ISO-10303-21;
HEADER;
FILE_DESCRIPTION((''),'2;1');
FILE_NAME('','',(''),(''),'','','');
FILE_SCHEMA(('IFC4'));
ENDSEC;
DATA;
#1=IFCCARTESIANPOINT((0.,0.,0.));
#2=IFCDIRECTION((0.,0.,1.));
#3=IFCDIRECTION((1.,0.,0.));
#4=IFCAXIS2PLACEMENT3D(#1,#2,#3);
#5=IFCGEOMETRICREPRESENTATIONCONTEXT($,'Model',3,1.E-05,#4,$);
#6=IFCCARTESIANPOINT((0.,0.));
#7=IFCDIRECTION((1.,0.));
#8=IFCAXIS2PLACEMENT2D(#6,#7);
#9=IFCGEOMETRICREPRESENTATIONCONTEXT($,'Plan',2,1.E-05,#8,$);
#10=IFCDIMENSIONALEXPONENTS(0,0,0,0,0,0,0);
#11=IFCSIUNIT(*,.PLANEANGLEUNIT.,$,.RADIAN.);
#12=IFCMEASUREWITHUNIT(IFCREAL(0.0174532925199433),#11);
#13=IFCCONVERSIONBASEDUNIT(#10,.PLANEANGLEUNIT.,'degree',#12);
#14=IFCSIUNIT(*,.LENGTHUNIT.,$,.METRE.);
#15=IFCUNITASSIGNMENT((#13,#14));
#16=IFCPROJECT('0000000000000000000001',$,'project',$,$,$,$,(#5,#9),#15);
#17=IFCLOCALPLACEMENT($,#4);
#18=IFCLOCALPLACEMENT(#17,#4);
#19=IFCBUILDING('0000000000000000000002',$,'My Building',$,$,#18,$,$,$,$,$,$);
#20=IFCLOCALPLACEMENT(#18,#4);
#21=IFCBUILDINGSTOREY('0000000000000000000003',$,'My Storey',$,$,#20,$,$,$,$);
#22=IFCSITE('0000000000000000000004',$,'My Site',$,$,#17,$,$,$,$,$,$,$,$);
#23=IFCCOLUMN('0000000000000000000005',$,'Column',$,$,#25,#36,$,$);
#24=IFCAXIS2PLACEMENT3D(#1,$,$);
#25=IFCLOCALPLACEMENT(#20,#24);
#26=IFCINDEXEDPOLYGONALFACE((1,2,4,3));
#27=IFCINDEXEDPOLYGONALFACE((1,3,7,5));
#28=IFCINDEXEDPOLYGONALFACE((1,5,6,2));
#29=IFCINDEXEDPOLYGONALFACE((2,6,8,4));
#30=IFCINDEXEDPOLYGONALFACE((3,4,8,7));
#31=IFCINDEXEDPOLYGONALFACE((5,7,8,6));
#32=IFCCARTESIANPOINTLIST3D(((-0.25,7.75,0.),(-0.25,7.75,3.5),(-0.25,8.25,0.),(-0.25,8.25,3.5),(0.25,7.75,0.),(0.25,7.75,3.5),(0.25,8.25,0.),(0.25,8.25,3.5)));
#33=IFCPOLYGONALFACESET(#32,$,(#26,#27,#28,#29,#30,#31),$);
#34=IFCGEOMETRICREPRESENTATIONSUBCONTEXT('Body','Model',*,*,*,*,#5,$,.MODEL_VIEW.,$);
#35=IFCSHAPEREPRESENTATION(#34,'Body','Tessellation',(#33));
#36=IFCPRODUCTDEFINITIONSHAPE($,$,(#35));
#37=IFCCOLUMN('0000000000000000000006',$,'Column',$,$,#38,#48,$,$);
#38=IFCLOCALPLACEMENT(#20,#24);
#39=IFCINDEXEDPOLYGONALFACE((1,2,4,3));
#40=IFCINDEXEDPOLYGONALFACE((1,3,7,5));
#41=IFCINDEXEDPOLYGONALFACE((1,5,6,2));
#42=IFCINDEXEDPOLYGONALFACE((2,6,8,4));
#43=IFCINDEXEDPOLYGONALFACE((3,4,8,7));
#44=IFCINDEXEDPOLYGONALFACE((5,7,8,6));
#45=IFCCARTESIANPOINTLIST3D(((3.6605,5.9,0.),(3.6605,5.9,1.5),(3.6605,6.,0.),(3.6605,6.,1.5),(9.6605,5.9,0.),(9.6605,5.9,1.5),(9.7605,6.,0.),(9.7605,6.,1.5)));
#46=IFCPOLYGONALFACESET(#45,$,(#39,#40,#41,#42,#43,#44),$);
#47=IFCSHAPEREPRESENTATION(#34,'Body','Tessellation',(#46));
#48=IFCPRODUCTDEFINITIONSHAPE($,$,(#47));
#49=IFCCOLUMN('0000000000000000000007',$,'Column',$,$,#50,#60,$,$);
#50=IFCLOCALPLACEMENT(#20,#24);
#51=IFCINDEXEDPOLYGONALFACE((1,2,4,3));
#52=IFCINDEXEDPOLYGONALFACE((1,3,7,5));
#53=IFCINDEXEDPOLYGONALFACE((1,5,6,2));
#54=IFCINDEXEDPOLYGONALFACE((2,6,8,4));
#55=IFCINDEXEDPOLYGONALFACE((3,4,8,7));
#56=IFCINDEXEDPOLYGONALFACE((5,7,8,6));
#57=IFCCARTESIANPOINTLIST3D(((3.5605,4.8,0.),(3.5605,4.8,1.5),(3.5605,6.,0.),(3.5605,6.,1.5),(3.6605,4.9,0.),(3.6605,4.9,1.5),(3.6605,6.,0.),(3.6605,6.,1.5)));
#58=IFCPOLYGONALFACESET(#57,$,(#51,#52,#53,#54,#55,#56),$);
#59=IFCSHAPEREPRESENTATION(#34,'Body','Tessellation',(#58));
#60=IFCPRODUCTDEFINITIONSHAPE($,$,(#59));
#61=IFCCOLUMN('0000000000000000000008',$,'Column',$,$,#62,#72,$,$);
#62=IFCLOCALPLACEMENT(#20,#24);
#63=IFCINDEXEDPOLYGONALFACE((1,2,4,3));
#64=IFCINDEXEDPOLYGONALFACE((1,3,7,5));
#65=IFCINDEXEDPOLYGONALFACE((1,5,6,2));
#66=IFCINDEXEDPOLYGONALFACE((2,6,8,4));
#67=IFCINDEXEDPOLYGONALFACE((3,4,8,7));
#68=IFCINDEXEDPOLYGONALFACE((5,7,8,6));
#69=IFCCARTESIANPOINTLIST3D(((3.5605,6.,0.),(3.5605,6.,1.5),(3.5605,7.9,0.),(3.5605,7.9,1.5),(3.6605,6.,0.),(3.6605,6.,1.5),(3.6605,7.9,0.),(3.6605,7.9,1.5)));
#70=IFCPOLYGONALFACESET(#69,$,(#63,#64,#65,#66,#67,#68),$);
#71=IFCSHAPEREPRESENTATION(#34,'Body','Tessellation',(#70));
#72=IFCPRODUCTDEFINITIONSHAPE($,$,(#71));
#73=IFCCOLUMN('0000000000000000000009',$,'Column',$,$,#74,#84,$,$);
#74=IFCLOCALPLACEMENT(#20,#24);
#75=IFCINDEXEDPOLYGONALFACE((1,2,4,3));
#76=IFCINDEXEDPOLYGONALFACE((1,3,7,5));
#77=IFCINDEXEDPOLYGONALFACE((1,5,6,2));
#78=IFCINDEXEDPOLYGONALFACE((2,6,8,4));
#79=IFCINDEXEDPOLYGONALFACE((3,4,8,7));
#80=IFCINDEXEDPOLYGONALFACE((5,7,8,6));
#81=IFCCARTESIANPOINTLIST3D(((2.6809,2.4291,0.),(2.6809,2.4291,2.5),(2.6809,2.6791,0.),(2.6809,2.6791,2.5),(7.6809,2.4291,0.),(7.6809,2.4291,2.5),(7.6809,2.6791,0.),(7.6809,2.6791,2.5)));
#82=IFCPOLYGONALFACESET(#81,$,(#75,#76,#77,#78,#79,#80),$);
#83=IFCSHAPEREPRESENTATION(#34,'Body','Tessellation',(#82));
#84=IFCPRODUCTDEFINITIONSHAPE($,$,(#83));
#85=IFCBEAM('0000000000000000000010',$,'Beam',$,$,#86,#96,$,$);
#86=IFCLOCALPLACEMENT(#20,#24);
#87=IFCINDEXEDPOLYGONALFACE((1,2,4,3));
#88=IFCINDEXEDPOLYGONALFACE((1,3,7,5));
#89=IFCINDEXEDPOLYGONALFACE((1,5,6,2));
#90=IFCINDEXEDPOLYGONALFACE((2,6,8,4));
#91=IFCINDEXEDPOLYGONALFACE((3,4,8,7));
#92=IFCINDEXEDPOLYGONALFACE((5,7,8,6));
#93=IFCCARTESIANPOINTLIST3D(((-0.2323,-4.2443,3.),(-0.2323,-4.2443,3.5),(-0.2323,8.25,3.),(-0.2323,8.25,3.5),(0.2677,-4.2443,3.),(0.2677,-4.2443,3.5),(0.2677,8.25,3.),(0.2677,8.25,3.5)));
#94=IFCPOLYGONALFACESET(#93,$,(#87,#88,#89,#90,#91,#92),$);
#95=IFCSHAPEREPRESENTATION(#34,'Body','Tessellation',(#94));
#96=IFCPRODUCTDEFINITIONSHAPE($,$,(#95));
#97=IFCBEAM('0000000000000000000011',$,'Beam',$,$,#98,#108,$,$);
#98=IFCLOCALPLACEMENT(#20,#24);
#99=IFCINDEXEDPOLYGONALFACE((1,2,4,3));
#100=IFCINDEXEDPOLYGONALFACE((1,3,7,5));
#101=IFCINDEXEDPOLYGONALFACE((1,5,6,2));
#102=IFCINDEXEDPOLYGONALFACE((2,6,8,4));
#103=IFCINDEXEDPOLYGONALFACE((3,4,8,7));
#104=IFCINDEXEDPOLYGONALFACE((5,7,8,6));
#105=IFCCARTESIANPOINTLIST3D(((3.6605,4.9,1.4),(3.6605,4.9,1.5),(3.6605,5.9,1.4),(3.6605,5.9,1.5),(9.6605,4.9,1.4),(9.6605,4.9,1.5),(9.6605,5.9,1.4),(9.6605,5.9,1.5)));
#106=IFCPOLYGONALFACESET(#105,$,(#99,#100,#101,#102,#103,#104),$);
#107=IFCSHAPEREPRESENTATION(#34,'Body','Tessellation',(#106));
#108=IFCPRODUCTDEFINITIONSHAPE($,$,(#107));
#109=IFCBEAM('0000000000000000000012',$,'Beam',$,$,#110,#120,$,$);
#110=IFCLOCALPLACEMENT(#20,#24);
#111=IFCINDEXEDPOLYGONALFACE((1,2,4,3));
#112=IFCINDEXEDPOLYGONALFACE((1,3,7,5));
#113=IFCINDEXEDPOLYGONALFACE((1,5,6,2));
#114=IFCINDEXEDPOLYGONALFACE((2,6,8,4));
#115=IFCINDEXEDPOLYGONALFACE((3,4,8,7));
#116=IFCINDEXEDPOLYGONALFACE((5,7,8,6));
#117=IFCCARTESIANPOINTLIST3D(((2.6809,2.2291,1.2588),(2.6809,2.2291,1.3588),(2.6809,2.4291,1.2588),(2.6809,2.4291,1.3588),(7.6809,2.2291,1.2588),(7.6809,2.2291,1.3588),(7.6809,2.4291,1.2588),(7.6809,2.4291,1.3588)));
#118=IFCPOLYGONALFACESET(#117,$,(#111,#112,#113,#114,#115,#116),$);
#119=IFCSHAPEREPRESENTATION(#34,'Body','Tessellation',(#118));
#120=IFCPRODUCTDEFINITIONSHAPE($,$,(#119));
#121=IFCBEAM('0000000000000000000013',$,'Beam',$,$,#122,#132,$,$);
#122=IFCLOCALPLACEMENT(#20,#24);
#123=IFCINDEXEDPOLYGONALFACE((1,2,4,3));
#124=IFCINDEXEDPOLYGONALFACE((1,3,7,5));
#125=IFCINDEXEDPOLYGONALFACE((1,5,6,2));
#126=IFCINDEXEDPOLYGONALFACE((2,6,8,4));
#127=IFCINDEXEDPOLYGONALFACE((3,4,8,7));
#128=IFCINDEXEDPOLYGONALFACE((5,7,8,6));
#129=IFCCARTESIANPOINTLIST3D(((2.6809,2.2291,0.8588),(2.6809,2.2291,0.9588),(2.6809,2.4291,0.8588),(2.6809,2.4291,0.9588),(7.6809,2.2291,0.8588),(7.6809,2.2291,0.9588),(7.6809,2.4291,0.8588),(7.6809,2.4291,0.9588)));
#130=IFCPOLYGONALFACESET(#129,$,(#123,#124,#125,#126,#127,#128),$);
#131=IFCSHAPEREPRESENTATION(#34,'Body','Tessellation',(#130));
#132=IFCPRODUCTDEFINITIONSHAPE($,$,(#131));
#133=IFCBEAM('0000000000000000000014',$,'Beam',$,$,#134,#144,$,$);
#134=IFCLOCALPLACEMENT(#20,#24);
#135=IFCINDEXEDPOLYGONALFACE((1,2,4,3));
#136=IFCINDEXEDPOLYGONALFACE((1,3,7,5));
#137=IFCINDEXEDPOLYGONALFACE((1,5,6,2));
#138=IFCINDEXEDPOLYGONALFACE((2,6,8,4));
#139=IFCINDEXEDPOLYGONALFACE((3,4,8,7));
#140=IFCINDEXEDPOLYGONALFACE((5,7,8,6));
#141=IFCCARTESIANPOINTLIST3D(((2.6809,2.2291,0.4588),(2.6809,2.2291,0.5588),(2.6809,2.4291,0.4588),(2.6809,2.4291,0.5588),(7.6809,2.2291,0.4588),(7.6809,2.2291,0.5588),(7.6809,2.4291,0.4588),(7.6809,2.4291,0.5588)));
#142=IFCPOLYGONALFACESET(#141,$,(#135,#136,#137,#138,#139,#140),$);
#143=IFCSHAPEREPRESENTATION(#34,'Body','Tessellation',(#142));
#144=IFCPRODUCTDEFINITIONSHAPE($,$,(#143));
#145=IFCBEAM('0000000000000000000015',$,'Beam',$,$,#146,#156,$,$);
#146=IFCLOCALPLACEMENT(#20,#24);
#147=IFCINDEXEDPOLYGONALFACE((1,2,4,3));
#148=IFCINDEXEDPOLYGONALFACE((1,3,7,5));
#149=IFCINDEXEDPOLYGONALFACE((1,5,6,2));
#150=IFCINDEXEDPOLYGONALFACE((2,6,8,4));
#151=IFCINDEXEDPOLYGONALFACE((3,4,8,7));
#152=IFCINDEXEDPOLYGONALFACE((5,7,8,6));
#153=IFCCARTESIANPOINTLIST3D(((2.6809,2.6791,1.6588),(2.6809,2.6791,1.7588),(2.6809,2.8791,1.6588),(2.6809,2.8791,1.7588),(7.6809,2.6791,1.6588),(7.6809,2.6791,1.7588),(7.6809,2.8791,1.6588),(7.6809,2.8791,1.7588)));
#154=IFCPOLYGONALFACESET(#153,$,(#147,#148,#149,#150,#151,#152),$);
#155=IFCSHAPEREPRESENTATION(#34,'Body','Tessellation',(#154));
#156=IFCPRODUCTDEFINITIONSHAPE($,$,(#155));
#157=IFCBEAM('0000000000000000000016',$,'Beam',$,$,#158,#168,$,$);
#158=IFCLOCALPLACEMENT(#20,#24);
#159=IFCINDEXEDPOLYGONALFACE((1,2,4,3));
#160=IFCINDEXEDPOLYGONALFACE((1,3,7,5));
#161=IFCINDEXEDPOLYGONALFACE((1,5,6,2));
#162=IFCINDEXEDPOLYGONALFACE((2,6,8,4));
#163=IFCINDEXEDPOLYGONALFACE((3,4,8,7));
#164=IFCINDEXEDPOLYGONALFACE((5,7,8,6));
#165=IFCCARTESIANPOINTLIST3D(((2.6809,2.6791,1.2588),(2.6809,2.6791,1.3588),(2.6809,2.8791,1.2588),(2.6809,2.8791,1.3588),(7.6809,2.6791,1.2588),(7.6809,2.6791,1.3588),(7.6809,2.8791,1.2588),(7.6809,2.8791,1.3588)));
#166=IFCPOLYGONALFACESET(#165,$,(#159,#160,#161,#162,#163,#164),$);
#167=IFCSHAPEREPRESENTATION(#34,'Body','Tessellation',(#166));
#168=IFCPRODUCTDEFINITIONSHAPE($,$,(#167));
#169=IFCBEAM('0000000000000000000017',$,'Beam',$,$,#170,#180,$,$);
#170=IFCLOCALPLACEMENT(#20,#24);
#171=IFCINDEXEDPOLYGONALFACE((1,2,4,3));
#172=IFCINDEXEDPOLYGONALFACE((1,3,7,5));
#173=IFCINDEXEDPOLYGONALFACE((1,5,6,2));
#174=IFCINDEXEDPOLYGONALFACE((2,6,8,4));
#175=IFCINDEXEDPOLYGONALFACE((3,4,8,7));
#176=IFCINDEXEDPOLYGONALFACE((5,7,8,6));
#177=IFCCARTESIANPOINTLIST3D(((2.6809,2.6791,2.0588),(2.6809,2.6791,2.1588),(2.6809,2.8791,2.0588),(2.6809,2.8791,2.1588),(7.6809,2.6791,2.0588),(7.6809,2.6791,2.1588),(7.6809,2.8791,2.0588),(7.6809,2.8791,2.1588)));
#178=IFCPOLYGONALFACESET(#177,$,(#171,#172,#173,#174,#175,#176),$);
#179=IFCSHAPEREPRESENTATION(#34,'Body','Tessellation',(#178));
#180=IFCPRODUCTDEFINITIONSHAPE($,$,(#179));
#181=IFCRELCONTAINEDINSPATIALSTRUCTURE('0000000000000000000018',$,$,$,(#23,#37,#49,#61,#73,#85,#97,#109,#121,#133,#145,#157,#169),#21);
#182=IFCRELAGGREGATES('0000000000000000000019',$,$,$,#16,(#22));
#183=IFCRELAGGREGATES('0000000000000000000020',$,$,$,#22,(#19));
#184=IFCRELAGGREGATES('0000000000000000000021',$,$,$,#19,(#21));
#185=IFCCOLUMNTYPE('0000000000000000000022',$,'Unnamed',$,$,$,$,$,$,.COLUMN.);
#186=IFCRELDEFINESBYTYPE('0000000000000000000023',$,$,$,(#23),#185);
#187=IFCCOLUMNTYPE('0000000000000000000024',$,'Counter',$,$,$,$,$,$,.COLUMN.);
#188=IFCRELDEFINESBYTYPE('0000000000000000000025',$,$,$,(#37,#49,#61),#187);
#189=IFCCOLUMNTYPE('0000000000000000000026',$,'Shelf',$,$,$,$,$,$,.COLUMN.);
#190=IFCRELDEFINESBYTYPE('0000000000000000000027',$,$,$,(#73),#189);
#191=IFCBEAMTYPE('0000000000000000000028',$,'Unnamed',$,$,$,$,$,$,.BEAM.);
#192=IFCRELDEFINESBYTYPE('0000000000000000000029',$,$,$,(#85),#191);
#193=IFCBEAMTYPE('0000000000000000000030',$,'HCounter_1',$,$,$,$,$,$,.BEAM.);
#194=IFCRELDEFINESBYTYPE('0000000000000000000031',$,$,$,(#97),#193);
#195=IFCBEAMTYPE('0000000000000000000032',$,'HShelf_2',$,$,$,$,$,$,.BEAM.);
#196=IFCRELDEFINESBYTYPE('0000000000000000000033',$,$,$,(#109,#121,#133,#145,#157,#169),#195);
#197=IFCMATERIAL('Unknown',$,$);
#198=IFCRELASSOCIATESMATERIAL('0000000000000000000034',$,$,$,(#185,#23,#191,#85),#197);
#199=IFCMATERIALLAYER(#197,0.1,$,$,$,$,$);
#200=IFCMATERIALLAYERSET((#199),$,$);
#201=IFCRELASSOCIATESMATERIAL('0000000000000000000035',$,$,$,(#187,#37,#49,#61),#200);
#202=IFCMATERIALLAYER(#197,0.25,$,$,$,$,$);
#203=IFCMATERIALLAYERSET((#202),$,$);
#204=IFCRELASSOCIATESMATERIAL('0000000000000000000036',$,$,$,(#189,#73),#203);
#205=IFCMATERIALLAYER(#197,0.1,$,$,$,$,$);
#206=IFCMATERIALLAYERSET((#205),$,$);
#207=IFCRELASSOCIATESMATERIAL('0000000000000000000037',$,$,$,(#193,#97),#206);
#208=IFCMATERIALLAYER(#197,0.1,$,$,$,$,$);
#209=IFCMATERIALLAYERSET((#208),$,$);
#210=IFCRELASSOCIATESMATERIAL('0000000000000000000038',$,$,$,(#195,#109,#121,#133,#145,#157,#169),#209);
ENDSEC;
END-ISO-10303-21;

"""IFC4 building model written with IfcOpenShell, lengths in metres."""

from ifc_helpers import new_model, entity, si_unit, converted_unit, frame, origin_with_axes, origin_2d_with_axis, place, context, subcontext, project, spatial, line, indexed_curve, rectangle, outline, extrude, material, layer, layer_set, layer_usage, material_profile, profile_set, profile_usage, type_object, element, save


model = new_model("IFC4")

# Units and contexts
model_context = context("Model", 3, precision=1e-05, world=origin_with_axes())
plan_context = context("Plan", 2, precision=1e-05, world=origin_2d_with_axis())
body_context_1 = subcontext(model_context, "Body", "Model", "MODEL_VIEW")
ifc_project = project(units=[converted_unit("PLANEANGLEUNIT", "degree", entity("IfcReal", 0.0174532925199433), si_unit("PLANEANGLEUNIT", "RADIAN"), dimensions=[0, 0, 0, 0, 0, 0, 0]), si_unit("LENGTHUNIT", "METRE")], contexts=[model_context, plan_context])

# Site, building, storey
site_placement = place(None, origin_with_axes())
site = spatial("IfcSite", under=ifc_project, at=site_placement, Name="My Site")
building_placement = place(site_placement, origin_with_axes())
building = spatial("IfcBuilding", under=site, at=building_placement, Name="My Building")
storey_placement = place(building_placement, origin_with_axes())
storey = spatial("IfcBuildingStorey", under=building, at=storey_placement, Name="My Storey")

# Columns
ifc_material = material(Name="Unknown")
ifc_material_profile_1 = material_profile(ifc_material, rectangle(XDim=0.5, YDim=0.5))
ifc_profile_set_1 = profile_set([ifc_material_profile_1])
ifc_profile_usage_1 = profile_usage(ifc_profile_set_1, cardinal=5)
column_type_1 = type_object("IfcColumnType", Name="Unnamed", PredefinedType="COLUMN", material=ifc_profile_set_1)
column_1_placement = place(storey_placement, frame((0.0, 8.0, 0.0), z_axis=(0.0, 0.0, 1.0), x_axis=(1.0, 0.0, 0.0)))
element("IfcColumn", 1, at=column_1_placement, inside=storey, type_object=column_type_1, material=ifc_profile_usage_1, Name="Column", context=body_context_1, shape_type="SweptSolid", body=[
    extrude(rectangle(XDim=0.5, YDim=0.5), origin_with_axes(), (0.0, 0.0, 1.0), 3.5),
])
ifc_layer_1 = layer(ifc_material, 0.1)
ifc_layer_set_1 = layer_set([ifc_layer_1])
ifc_layer_usage_1 = layer_usage(ifc_layer_set_1, "AXIS2", "POSITIVE", 0.0)
column_type_2 = type_object("IfcColumnType", Name="Counter", PredefinedType="COLUMN", material=ifc_layer_set_1)
column_2_placement = place(storey_placement, frame((3.6605, 5.9, 0.0), z_axis=(0.0, 0.0, 1.0), x_axis=(1.0, 0.0, 0.0)))
element("IfcColumn", 2, at=column_2_placement, inside=storey, type_object=column_type_2, material=ifc_layer_usage_1, Name="Column", context=body_context_1, shape_type="SweptSolid", body=[
    extrude(outline(indexed_curve([(0.0, 0.0), (0.0, 0.1), (6.1, 0.1), (6.0, 0.0)], segments=[line(1, 2, 3, 4, 1)])), origin_with_axes(), (0.0, 0.0, 1.0), 1.5),
])
ifc_layer_usage_2 = layer_usage(ifc_layer_set_1, "AXIS2", "POSITIVE", 0.0)
column_3_placement = place(storey_placement, frame((3.6605, 4.9, 0.0), z_axis=(0.0, 0.0, 1.0), x_axis=(0.0, 1.0, 0.0)))
element("IfcColumn", 3, at=column_3_placement, inside=storey, type_object=column_type_2, material=ifc_layer_usage_2, Name="Column", context=body_context_1, shape_type="SweptSolid", body=[
    extrude(outline(indexed_curve([(0.0, 0.0), (-0.1, 0.1), (1.1, 0.1), (1.1, 0.0)], segments=[line(1, 2, 3, 4, 1)])), origin_with_axes(), (0.0, 0.0, 1.0), 1.5),
])
ifc_layer_usage_3 = layer_usage(ifc_layer_set_1, "AXIS2", "POSITIVE", 0.0)
column_4_placement = place(storey_placement, frame((3.6605, 6.0, 0.0), z_axis=(0.0, 0.0, 1.0), x_axis=(0.0, 1.0, 0.0)))
element("IfcColumn", 4, at=column_4_placement, inside=storey, type_object=column_type_2, material=ifc_layer_usage_3, Name="Column", context=body_context_1, shape_type="SweptSolid", body=[
    extrude(outline(indexed_curve([(0.0, 0.0), (0.0, 0.1), (1.9, 0.1), (1.9, 0.0)], segments=[line(1, 2, 3, 4, 1)])), origin_with_axes(), (0.0, 0.0, 1.0), 1.5),
])
ifc_layer_2 = layer(ifc_material, 0.25)
ifc_layer_set_2 = layer_set([ifc_layer_2])
ifc_layer_usage_4 = layer_usage(ifc_layer_set_2, "AXIS2", "POSITIVE", 0.0)
column_type_3 = type_object("IfcColumnType", Name="Shelf", PredefinedType="COLUMN", material=ifc_layer_set_2)
column_5_placement = place(storey_placement, frame((7.6809, 2.6791, 0.0), z_axis=(0.0, 0.0, 1.0), x_axis=(-1.0, 0.0, 0.0)))
element("IfcColumn", 5, at=column_5_placement, inside=storey, type_object=column_type_3, material=ifc_layer_usage_4, Name="Column", context=body_context_1, shape_type="SweptSolid", body=[
    extrude(outline(indexed_curve([(0.0, 0.0), (0.0, 0.25), (5.0, 0.25), (5.0, 0.0)], segments=[line(1, 2, 3, 4, 1)])), origin_with_axes(), (0.0, 0.0, 1.0), 2.5),
])

# Beams
ifc_material_profile_2 = material_profile(ifc_material, rectangle(XDim=0.5, YDim=0.5))
ifc_profile_set_2 = profile_set([ifc_material_profile_2])
ifc_profile_usage_2 = profile_usage(ifc_profile_set_2, cardinal=2)
beam_type_1 = type_object("IfcBeamType", Name="Unnamed", PredefinedType="BEAM", material=ifc_profile_set_2)
beam_1_placement = place(storey_placement, frame((0.0177, 8.25, 3.0), z_axis=(0.0, -1.0, 0.0), x_axis=(1.0, 0.0, 0.0)))
element("IfcBeam", 6, at=beam_1_placement, inside=storey, type_object=beam_type_1, material=ifc_profile_usage_2, Name="Beam", context=body_context_1, shape_type="SweptSolid", body=[
    extrude(rectangle(XDim=0.5, YDim=0.5), frame((0.0, 0.25, 0.0), z_axis=(0.0, 0.0, 1.0), x_axis=(1.0, 0.0, 0.0)), (0.0, 0.0, 1.0), 12.4943),
])
ifc_layer_3 = layer(ifc_material, 0.1)
ifc_layer_set_3 = layer_set([ifc_layer_3])
ifc_layer_usage_5 = layer_usage(ifc_layer_set_3, "AXIS3", "POSITIVE", -0.1)
beam_type_2 = type_object("IfcBeamType", Name="HCounter_1", PredefinedType="BEAM", material=ifc_layer_set_3)
beam_2_placement = place(storey_placement, frame((3.6605, 5.9, 1.5), z_axis=(0.0, 0.0, 1.0), x_axis=(1.0, 0.0, 0.0)))
element("IfcBeam", 7, at=beam_2_placement, inside=storey, type_object=beam_type_2, material=ifc_layer_usage_5, Name="Beam", context=body_context_1, shape_type="SweptSolid", body=[
    extrude(outline(indexed_curve([(0.0, 0.0), (6.0, 0.0), (6.0, -1.0), (0.0, -1.0), (0.0, 0.0)])), frame((0.0, 0.0, -0.1), z_axis=(0.0, 0.0, 1.0), x_axis=(1.0, 0.0, 0.0)), (0.0, 0.0, 1.0), 0.1),
])
ifc_layer_4 = layer(ifc_material, 0.1)
ifc_layer_set_4 = layer_set([ifc_layer_4])
ifc_layer_usage_6 = layer_usage(ifc_layer_set_4, "AXIS3", "POSITIVE", -0.1)
beam_type_3 = type_object("IfcBeamType", Name="HShelf_2", PredefinedType="BEAM", material=ifc_layer_set_4)
beam_3_placement = place(storey_placement, frame((2.6809, 2.4291, 1.3588), z_axis=(0.0, 0.0, 1.0), x_axis=(1.0, 0.0, 0.0)))
element("IfcBeam", 8, at=beam_3_placement, inside=storey, type_object=beam_type_3, material=ifc_layer_usage_6, Name="Beam", context=body_context_1, shape_type="SweptSolid", body=[
    extrude(outline(indexed_curve([(0.0, 0.0), (0.0, -0.2), (5.0, -0.2), (5.0, 0.0), (0.0, 0.0)])), frame((0.0, 0.0, -0.1), z_axis=(0.0, 0.0, 1.0), x_axis=(1.0, 0.0, 0.0)), (0.0, 0.0, 1.0), 0.1),
])
ifc_layer_usage_7 = layer_usage(ifc_layer_set_4, "AXIS3", "POSITIVE", -0.1)
beam_4_placement = place(storey_placement, frame((2.6809, 2.4291, 0.9588), z_axis=(0.0, 0.0, 1.0), x_axis=(1.0, 0.0, 0.0)))
element("IfcBeam", 9, at=beam_4_placement, inside=storey, type_object=beam_type_3, material=ifc_layer_usage_7, Name="Beam", context=body_context_1, shape_type="SweptSolid", body=[
    extrude(outline(indexed_curve([(0.0, 0.0), (0.0, -0.2), (5.0, -0.2), (5.0, 0.0), (0.0, 0.0)])), frame((0.0, 0.0, -0.1), z_axis=(0.0, 0.0, 1.0), x_axis=(1.0, 0.0, 0.0)), (0.0, 0.0, 1.0), 0.1),
])
ifc_layer_usage_8 = layer_usage(ifc_layer_set_4, "AXIS3", "POSITIVE", -0.1)
beam_5_placement = place(storey_placement, frame((2.6809, 2.4291, 0.5588), z_axis=(0.0, 0.0, 1.0), x_axis=(1.0, 0.0, 0.0)))
element("IfcBeam", 10, at=beam_5_placement, inside=storey, type_object=beam_type_3, material=ifc_layer_usage_8, Name="Beam", context=body_context_1, shape_type="SweptSolid", body=[
    extrude(outline(indexed_curve([(0.0, 0.0), (0.0, -0.2), (5.0, -0.2), (5.0, 0.0), (0.0, 0.0)])), frame((0.0, 0.0, -0.1), z_axis=(0.0, 0.0, 1.0), x_axis=(1.0, 0.0, 0.0)), (0.0, 0.0, 1.0), 0.1),
])
ifc_layer_usage_9 = layer_usage(ifc_layer_set_4, "AXIS3", "POSITIVE", -0.1)
beam_6_placement = place(storey_placement, frame((2.6809, 2.8791, 1.7588), z_axis=(0.0, 0.0, 1.0), x_axis=(1.0, 0.0, 0.0)))
element("IfcBeam", 11, at=beam_6_placement, inside=storey, type_object=beam_type_3, material=ifc_layer_usage_9, Name="Beam", context=body_context_1, shape_type="SweptSolid", body=[
    extrude(outline(indexed_curve([(0.0, 0.0), (0.0, -0.2), (5.0, -0.2), (5.0, 0.0), (0.0, 0.0)])), frame((0.0, 0.0, -0.1), z_axis=(0.0, 0.0, 1.0), x_axis=(1.0, 0.0, 0.0)), (0.0, 0.0, 1.0), 0.1),
])
ifc_layer_usage_10 = layer_usage(ifc_layer_set_4, "AXIS3", "POSITIVE", -0.1)
beam_7_placement = place(storey_placement, frame((2.6809, 2.8791, 1.3588), z_axis=(0.0, 0.0, 1.0), x_axis=(1.0, 0.0, 0.0)))
element("IfcBeam", 12, at=beam_7_placement, inside=storey, type_object=beam_type_3, material=ifc_layer_usage_10, Name="Beam", context=body_context_1, shape_type="SweptSolid", body=[
    extrude(outline(indexed_curve([(0.0, 0.0), (0.0, -0.2), (5.0, -0.2), (5.0, 0.0), (0.0, 0.0)])), frame((0.0, 0.0, -0.1), z_axis=(0.0, 0.0, 1.0), x_axis=(1.0, 0.0, 0.0)), (0.0, 0.0, 1.0), 0.1),
])
ifc_layer_usage_11 = layer_usage(ifc_layer_set_4, "AXIS3", "POSITIVE", -0.1)
beam_8_placement = place(storey_placement, frame((2.6809, 2.8791, 2.1588), z_axis=(0.0, 0.0, 1.0), x_axis=(1.0, 0.0, 0.0)))
element("IfcBeam", 13, at=beam_8_placement, inside=storey, type_object=beam_type_3, material=ifc_layer_usage_11, Name="Beam", context=body_context_1, shape_type="SweptSolid", body=[
    extrude(outline(indexed_curve([(0.0, 0.0), (0.0, -0.2), (5.0, -0.2), (5.0, 0.0), (0.0, 0.0)])), frame((0.0, 0.0, -0.1), z_axis=(0.0, 0.0, 1.0), x_axis=(1.0, 0.0, 0.0)), (0.0, 0.0, 1.0), 0.1),
])

save(model, "model.ifc")
